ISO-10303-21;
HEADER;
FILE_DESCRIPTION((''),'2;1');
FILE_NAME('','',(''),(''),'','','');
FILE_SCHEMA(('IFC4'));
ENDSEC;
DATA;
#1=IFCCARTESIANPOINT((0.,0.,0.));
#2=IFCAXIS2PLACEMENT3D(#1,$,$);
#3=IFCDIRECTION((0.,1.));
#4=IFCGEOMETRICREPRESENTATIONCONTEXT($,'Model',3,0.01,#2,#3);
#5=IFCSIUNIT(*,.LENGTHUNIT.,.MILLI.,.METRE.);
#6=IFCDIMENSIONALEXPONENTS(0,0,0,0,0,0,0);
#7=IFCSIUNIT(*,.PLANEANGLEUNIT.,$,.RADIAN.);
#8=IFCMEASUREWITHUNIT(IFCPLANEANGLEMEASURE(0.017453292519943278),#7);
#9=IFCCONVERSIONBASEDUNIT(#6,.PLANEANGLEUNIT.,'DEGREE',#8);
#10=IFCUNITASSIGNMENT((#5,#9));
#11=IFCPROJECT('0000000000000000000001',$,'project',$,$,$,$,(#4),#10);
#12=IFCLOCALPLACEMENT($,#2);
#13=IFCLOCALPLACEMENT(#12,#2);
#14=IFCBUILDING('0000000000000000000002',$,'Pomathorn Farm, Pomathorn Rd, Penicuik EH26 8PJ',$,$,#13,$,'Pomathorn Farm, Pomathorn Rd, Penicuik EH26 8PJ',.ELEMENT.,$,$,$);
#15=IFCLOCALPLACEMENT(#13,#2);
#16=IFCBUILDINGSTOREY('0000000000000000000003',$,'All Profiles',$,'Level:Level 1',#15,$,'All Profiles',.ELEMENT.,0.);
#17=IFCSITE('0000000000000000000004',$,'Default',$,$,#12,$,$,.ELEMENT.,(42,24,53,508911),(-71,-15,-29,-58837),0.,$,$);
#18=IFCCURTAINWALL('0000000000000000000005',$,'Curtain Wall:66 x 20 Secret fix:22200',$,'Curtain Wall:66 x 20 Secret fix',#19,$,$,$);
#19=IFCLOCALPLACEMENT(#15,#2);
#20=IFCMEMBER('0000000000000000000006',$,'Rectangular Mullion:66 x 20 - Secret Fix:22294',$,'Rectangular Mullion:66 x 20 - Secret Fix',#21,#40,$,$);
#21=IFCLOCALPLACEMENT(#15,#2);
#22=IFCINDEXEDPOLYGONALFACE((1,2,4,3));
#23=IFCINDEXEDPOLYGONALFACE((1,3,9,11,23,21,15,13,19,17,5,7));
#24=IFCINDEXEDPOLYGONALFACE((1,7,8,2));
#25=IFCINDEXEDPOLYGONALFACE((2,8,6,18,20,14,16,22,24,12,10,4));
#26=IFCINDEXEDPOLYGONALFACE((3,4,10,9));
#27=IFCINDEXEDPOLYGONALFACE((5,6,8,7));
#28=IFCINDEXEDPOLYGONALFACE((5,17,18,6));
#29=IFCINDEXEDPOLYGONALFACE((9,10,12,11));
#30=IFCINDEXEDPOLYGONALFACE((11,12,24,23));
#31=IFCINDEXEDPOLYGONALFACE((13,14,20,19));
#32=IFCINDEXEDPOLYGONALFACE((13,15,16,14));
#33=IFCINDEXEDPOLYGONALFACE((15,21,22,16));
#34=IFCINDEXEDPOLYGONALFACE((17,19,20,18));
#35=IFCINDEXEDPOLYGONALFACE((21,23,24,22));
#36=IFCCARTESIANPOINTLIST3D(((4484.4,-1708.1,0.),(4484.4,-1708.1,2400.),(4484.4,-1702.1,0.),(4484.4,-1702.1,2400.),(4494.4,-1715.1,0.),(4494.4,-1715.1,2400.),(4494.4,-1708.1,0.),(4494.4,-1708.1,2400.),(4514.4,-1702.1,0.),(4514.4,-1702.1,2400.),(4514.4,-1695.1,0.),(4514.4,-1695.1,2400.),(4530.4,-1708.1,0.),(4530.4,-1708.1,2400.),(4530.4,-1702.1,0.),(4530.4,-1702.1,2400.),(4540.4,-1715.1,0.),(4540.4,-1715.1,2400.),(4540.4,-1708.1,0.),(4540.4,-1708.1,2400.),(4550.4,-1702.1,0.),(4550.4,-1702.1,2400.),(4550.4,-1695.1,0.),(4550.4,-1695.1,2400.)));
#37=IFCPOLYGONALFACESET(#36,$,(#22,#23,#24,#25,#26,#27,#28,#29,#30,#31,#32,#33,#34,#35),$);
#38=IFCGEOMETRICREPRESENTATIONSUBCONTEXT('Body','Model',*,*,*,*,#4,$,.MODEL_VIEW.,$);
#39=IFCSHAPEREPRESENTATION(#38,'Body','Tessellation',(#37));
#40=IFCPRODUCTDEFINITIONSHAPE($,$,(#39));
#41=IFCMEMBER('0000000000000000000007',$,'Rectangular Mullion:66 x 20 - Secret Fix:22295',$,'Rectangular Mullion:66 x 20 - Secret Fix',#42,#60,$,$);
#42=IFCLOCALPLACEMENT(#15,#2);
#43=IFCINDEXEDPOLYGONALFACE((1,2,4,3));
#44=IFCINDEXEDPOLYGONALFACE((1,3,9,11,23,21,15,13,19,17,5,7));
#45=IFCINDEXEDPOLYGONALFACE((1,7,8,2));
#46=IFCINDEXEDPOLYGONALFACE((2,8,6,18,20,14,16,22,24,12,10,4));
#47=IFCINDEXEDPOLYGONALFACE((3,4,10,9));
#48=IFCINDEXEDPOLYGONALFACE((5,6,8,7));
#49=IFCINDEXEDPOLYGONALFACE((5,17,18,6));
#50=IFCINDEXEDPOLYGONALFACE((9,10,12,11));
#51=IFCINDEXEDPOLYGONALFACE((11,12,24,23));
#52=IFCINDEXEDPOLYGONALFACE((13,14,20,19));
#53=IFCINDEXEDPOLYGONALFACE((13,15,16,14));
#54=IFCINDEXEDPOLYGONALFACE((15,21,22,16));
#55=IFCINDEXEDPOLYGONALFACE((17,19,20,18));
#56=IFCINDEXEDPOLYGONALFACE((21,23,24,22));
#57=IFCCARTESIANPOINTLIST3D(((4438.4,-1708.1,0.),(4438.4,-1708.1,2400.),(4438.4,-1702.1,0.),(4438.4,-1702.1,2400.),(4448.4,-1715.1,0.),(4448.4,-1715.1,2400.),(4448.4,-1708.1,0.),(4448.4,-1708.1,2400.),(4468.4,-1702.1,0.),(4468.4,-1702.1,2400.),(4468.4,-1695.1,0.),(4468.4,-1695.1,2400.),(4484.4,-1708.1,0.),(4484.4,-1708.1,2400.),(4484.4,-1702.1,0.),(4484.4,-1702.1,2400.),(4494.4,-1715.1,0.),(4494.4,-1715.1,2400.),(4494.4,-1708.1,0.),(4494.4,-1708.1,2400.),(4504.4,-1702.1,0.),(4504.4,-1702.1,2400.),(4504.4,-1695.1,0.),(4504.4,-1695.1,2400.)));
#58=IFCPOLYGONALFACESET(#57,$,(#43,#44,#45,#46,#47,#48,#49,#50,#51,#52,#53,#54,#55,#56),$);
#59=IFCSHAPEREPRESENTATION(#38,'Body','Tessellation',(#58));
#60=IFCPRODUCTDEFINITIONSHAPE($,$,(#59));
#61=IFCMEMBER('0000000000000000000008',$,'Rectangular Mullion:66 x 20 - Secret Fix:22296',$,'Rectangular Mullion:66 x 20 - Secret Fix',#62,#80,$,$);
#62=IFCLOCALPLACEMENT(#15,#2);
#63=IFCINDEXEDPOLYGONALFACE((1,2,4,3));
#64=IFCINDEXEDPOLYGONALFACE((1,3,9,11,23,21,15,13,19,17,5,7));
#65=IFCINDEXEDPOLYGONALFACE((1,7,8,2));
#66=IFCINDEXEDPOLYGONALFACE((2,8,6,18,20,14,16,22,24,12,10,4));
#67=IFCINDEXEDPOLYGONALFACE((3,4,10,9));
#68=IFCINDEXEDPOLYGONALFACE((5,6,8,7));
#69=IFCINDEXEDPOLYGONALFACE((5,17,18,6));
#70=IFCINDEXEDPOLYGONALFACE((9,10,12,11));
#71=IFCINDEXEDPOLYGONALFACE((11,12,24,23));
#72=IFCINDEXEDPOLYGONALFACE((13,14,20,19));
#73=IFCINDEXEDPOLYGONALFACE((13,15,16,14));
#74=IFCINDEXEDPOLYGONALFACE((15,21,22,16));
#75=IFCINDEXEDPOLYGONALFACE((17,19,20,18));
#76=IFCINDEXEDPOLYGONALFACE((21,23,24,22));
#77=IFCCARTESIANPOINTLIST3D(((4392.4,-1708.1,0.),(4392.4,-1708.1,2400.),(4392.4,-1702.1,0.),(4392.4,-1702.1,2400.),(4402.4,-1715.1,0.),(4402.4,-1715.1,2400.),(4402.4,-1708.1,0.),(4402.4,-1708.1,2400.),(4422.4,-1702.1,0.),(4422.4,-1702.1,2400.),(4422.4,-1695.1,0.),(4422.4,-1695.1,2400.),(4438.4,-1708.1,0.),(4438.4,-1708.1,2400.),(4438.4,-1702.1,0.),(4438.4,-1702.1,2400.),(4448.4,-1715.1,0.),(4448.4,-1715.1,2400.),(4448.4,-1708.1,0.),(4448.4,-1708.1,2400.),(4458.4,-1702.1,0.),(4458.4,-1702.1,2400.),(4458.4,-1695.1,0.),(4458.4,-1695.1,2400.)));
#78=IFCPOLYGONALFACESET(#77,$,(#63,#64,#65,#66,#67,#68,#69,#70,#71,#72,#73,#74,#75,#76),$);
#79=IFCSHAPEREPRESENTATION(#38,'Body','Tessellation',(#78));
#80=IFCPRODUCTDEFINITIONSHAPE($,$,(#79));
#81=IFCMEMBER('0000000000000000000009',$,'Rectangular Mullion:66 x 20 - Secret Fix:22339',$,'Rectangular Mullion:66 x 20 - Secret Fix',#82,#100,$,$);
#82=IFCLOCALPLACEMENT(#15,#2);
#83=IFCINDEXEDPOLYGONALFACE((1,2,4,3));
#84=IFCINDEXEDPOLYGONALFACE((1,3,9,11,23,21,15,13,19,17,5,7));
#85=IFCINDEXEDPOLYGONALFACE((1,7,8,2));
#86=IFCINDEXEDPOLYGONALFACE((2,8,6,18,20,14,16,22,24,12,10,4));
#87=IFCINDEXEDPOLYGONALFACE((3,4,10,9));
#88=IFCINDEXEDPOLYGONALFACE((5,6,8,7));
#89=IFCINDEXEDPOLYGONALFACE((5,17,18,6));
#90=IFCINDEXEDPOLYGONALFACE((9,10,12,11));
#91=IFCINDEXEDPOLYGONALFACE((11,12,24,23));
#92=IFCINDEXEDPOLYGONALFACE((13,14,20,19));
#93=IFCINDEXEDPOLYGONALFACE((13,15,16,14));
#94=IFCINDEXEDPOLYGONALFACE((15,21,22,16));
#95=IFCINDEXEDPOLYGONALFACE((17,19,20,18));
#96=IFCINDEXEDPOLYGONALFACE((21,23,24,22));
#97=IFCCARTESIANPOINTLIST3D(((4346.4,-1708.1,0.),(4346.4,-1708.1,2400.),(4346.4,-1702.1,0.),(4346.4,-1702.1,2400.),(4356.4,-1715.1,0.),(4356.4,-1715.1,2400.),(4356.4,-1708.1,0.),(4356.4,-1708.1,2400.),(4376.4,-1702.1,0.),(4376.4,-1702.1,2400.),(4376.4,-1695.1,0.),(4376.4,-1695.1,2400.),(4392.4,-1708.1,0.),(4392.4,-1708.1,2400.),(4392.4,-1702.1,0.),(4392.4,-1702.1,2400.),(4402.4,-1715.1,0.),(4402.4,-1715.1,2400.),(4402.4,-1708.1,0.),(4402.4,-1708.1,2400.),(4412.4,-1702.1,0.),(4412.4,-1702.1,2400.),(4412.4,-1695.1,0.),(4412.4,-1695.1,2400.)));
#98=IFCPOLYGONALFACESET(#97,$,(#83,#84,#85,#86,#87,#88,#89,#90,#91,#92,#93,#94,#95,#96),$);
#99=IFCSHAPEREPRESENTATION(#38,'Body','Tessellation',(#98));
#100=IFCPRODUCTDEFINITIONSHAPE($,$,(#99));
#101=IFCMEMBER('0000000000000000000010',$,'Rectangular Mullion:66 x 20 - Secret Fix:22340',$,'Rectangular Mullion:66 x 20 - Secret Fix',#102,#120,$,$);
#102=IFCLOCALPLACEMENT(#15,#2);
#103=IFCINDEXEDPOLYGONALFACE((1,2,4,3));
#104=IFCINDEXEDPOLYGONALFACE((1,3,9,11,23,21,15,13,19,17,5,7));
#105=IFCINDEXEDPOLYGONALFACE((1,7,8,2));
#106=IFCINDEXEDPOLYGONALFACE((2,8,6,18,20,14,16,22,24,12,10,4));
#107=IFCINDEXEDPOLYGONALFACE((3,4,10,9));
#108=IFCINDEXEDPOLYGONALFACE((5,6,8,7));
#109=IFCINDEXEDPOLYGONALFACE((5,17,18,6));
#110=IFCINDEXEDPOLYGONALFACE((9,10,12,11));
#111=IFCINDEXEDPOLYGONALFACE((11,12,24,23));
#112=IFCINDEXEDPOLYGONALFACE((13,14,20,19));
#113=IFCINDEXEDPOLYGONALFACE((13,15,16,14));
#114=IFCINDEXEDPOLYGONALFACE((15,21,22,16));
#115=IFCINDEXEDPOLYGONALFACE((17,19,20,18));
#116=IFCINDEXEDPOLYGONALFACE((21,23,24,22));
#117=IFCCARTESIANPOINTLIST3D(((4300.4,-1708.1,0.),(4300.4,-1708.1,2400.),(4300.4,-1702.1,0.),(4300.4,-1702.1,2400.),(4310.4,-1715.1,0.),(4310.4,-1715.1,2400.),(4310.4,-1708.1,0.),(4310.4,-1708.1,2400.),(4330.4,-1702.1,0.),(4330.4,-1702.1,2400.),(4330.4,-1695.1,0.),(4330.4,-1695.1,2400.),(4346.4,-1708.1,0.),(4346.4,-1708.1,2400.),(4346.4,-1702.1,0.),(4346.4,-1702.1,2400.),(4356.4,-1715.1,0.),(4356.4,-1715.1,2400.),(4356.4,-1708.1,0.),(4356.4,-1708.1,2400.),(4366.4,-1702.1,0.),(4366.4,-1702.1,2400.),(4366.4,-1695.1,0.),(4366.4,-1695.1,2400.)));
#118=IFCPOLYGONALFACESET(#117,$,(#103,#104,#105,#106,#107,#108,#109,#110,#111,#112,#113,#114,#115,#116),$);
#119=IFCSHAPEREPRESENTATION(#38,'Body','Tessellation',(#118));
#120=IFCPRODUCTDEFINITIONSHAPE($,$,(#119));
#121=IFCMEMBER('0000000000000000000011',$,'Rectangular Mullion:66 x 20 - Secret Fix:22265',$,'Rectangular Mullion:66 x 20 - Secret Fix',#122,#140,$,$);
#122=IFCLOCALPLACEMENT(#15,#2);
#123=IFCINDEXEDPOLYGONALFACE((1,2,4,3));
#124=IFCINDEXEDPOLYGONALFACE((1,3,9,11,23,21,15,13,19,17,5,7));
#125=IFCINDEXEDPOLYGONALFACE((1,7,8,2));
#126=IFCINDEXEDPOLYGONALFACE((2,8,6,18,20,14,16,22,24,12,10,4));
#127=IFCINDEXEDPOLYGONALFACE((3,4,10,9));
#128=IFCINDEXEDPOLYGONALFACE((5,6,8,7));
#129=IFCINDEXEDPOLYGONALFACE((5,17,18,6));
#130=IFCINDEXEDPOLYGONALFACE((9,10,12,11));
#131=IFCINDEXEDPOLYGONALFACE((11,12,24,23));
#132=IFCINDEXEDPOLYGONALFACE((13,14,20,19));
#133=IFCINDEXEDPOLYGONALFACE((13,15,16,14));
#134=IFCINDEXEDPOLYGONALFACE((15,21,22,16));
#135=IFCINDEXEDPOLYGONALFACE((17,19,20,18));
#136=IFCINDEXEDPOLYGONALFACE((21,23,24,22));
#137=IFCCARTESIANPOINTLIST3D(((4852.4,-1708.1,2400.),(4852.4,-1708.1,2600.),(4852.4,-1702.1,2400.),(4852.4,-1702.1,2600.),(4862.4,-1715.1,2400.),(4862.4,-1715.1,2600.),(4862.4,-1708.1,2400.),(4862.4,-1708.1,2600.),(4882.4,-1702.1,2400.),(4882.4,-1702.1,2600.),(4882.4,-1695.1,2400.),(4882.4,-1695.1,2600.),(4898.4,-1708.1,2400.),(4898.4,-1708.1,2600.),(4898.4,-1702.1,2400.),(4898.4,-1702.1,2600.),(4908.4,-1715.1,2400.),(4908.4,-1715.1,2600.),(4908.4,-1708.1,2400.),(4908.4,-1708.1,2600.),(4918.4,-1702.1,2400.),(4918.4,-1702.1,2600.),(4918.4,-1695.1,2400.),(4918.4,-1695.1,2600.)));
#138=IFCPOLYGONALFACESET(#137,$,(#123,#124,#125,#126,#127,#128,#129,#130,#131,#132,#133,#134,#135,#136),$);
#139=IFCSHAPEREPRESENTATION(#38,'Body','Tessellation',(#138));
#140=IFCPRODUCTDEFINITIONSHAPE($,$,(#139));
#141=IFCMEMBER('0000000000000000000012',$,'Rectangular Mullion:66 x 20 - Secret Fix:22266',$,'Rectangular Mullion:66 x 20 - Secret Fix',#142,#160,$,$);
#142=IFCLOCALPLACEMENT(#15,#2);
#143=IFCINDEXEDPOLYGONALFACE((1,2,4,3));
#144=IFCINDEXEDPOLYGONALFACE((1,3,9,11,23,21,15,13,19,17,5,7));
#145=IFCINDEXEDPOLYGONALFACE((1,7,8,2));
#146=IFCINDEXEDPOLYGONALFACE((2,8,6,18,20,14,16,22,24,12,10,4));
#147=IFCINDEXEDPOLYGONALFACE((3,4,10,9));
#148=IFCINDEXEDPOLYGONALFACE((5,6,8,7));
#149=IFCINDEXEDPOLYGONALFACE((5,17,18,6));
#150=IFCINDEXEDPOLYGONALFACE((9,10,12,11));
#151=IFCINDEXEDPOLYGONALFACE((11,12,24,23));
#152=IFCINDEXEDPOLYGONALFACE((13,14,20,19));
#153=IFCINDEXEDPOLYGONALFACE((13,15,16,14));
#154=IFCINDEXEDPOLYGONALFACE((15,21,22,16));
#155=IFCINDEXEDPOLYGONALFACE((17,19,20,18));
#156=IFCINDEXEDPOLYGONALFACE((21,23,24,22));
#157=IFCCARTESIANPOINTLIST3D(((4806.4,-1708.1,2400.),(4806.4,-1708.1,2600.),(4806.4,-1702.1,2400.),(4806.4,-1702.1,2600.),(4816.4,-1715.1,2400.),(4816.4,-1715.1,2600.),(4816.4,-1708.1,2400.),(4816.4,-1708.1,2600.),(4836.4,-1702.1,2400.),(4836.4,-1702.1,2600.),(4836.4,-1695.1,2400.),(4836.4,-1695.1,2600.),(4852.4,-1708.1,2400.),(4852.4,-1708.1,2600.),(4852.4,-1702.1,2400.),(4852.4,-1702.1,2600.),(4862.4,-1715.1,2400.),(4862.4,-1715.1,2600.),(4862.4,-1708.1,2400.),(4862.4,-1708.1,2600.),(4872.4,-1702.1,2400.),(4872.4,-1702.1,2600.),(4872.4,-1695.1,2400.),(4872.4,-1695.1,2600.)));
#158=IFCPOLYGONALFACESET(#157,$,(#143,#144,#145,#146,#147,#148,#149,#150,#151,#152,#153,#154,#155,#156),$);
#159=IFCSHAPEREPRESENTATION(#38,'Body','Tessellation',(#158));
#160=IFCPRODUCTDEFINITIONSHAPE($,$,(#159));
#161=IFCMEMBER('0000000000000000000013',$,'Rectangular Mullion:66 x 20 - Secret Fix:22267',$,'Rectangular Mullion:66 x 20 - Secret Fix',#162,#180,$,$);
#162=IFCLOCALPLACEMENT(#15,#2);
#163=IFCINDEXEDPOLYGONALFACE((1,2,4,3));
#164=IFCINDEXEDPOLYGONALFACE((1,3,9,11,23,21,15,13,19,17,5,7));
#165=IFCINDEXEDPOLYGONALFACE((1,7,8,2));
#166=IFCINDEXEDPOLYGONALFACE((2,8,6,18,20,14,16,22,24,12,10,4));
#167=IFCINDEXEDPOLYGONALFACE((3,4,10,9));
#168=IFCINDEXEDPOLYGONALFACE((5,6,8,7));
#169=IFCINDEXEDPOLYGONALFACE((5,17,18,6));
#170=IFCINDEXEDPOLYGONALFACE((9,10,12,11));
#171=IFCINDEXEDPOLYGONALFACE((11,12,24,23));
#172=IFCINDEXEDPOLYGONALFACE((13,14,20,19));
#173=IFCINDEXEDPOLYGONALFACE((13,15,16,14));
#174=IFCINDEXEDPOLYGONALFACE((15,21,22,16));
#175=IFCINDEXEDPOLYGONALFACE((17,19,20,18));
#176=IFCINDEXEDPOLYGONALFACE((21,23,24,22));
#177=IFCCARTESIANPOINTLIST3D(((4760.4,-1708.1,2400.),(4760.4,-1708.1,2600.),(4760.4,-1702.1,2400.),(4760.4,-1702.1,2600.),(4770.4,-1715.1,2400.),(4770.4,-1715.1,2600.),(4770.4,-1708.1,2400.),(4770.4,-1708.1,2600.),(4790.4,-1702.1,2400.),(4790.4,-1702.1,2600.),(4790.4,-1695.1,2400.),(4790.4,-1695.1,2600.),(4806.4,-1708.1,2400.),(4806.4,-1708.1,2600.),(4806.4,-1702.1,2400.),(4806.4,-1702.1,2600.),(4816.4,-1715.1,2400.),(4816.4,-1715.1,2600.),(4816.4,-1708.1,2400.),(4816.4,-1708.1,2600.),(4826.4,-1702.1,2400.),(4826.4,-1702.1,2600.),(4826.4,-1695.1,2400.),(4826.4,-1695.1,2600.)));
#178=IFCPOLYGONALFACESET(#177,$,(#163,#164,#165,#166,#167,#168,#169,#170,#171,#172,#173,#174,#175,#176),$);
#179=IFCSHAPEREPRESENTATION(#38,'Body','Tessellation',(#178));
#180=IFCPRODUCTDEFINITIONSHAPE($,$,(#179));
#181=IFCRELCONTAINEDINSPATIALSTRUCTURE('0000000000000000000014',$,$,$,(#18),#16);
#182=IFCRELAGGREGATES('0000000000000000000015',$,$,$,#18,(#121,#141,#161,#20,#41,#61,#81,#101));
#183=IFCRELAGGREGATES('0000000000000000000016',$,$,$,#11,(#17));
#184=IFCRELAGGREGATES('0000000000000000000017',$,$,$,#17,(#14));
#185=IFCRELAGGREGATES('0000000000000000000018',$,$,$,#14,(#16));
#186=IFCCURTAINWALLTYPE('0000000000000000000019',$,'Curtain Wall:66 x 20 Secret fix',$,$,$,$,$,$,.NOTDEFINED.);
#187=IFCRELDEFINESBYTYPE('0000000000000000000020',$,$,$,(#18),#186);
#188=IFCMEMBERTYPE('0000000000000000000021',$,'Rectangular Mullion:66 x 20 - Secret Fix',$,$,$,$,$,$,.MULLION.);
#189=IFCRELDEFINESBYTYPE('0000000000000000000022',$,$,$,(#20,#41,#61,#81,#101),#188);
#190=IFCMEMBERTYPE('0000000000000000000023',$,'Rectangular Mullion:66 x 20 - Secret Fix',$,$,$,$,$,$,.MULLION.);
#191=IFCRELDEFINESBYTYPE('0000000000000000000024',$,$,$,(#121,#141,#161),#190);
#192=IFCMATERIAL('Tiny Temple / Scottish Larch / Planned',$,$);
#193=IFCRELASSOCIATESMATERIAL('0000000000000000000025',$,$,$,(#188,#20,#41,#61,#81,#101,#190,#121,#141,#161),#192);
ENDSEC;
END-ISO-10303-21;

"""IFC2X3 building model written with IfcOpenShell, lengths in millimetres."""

from ifc_helpers import new_model, entity, si_unit, converted_unit, direction, frame, origin, place, context, subcontext, project, spatial, polyline, outline, extrude, source, transform, mapped, material, type_object, type_shapes, element, aggregate, save


model = new_model("IFC2X3")

# Units and contexts
model_context = context("Model", 3, precision=0.01, world=origin(), true_north=direction((0.0, 1.0)))
body_context = subcontext(model_context, "Body", "Model", "MODEL_VIEW")
ifc_project = project(units=[si_unit("LENGTHUNIT", "METRE", prefix="MILLI"), converted_unit("PLANEANGLEUNIT", "DEGREE", entity("IfcPlaneAngleMeasure", 0.017453292519943278), si_unit("PLANEANGLEUNIT", "RADIAN"), dimensions=[0, 0, 0, 0, 0, 0, 0])], contexts=[model_context])

# Site, building, storey
site_placement = place(None, origin())
site = spatial("IfcSite", under=ifc_project, at=site_placement, Name="Default", CompositionType="ELEMENT", RefLatitude=(42, 24, 53, 508911), RefLongitude=(-71, -15, -29, -58837), RefElevation=0.0)
building_placement = place(site_placement, origin())
building = spatial("IfcBuilding", under=site, at=building_placement, Name="Pomathorn Farm, Pomathorn Rd, Penicuik EH26 8PJ", LongName="Pomathorn Farm, Pomathorn Rd, Penicuik EH26 8PJ", CompositionType="ELEMENT")
storey_placement = place(building_placement, origin())
storey = spatial("IfcBuildingStorey", under=building, at=storey_placement, Name="All Profiles", ObjectType="Level:Level 1", LongName="All Profiles", CompositionType="ELEMENT", Elevation=0.0)

# Curtain wall, members
curtain_wall_type = type_object("IfcCurtainWallType", Name="Curtain Wall:66 x 20 Secret fix", PredefinedType="NOTDEFINED")
curtain_wall_placement = place(storey_placement, origin())
curtain_wall = element("IfcCurtainWall", 1, at=curtain_wall_placement, inside=storey, type_object=curtain_wall_type, Name="Curtain Wall:66 x 20 Secret fix:22200", ObjectType="Curtain Wall:66 x 20 Secret fix")
ifc_material = material(Name="Tiny Temple / Scottish Larch / Planned")
member_type_1 = type_object("IfcMemberType", Name="Rectangular Mullion:66 x 20 - Secret Fix", PredefinedType="MULLION", material=ifc_material)
shared_shape_1 = source(origin(), body_context, "Body", "SweptSolid", [
    extrude(outline(polyline([(-3.0, -34.7), (3.0, -34.7), (3.0, -4.7), (10.0, -4.7), (10.0, 31.3), (3.0, 31.3), (3.0, 11.3), (-3.0, 11.3), (-3.0, 21.3), (-10.0, 21.3), (-10.0, -24.7), (-3.0, -24.7), (-3.0, -34.7)])), frame((-31.3, -10.0, -2400.0), z_axis=(0.0, 0.0, 1.0), x_axis=(0.0, -1.0, 0.0)), (0.0, 0.0, 1.0), 2400.0),
])
type_shapes(member_type_1, [shared_shape_1])
member_1_placement = place(curtain_wall_placement, frame((4550.4, -1715.1, 0.0), z_axis=(0.0, 0.0, -1.0), x_axis=(1.0, 0.0, 0.0)))
member_1 = element("IfcMember", 2, at=member_1_placement, type_object=member_type_1, material=ifc_material, Name="Rectangular Mullion:66 x 20 - Secret Fix:22294", ObjectType="Rectangular Mullion:66 x 20 - Secret Fix", context=body_context, shape_type="MappedRepresentation", body=[
    mapped(shared_shape_1, transform((0.0, 0.0, 0.0), scale=1.0)),
])
member_2_placement = place(curtain_wall_placement, frame((4504.4, -1715.1, 0.0), z_axis=(0.0, 0.0, -1.0), x_axis=(1.0, 0.0, 0.0)))
member_2 = element("IfcMember", 3, at=member_2_placement, type_object=member_type_1, material=ifc_material, Name="Rectangular Mullion:66 x 20 - Secret Fix:22295", ObjectType="Rectangular Mullion:66 x 20 - Secret Fix", context=body_context, shape_type="MappedRepresentation", body=[
    mapped(shared_shape_1, transform((0.0, 0.0, 0.0), scale=1.0)),
])
member_3_placement = place(curtain_wall_placement, frame((4458.4, -1715.1, 0.0), z_axis=(0.0, 0.0, -1.0), x_axis=(1.0, 0.0, 0.0)))
member_3 = element("IfcMember", 4, at=member_3_placement, type_object=member_type_1, material=ifc_material, Name="Rectangular Mullion:66 x 20 - Secret Fix:22296", ObjectType="Rectangular Mullion:66 x 20 - Secret Fix", context=body_context, shape_type="MappedRepresentation", body=[
    mapped(shared_shape_1, transform((0.0, 0.0, 0.0), scale=1.0)),
])
member_4_placement = place(curtain_wall_placement, frame((4412.4, -1715.1, 0.0), z_axis=(0.0, 0.0, -1.0), x_axis=(1.0, 0.0, 0.0)))
member_4 = element("IfcMember", 5, at=member_4_placement, type_object=member_type_1, material=ifc_material, Name="Rectangular Mullion:66 x 20 - Secret Fix:22339", ObjectType="Rectangular Mullion:66 x 20 - Secret Fix", context=body_context, shape_type="MappedRepresentation", body=[
    mapped(shared_shape_1, transform((0.0, 0.0, 0.0), scale=1.0)),
])
member_5_placement = place(curtain_wall_placement, frame((4366.4, -1715.1, 0.0), z_axis=(0.0, 0.0, -1.0), x_axis=(1.0, 0.0, 0.0)))
member_5 = element("IfcMember", 6, at=member_5_placement, type_object=member_type_1, material=ifc_material, Name="Rectangular Mullion:66 x 20 - Secret Fix:22340", ObjectType="Rectangular Mullion:66 x 20 - Secret Fix", context=body_context, shape_type="MappedRepresentation", body=[
    mapped(shared_shape_1, transform((0.0, 0.0, 0.0), scale=1.0)),
])
member_type_2 = type_object("IfcMemberType", Name="Rectangular Mullion:66 x 20 - Secret Fix", PredefinedType="MULLION", material=ifc_material)
shared_shape_2 = source(origin(), body_context, "Body", "SweptSolid", [
    extrude(outline(polyline([(-3.0, -34.7), (3.0, -34.7), (3.0, -4.7), (10.0, -4.7), (10.0, 31.3), (3.0, 31.3), (3.0, 11.3), (-3.0, 11.3), (-3.0, 21.3), (-10.0, 21.3), (-10.0, -24.7), (-3.0, -24.7), (-3.0, -34.7)])), frame((-31.3, -10.0, -200.0), z_axis=(0.0, 0.0, 1.0), x_axis=(0.0, -1.0, 0.0)), (0.0, 0.0, 1.0), 200.0),
])
type_shapes(member_type_2, [shared_shape_2])
member_6_placement = place(curtain_wall_placement, frame((4918.4, -1715.1, 2400.0), z_axis=(0.0, 0.0, -1.0), x_axis=(1.0, 0.0, 0.0)))
member_6 = element("IfcMember", 7, at=member_6_placement, type_object=member_type_2, material=ifc_material, Name="Rectangular Mullion:66 x 20 - Secret Fix:22265", ObjectType="Rectangular Mullion:66 x 20 - Secret Fix", context=body_context, shape_type="MappedRepresentation", body=[
    mapped(shared_shape_2, transform((0.0, 0.0, 0.0), scale=1.0)),
])
member_7_placement = place(curtain_wall_placement, frame((4872.4, -1715.1, 2400.0), z_axis=(0.0, 0.0, -1.0), x_axis=(1.0, 0.0, 0.0)))
member_7 = element("IfcMember", 8, at=member_7_placement, type_object=member_type_2, material=ifc_material, Name="Rectangular Mullion:66 x 20 - Secret Fix:22266", ObjectType="Rectangular Mullion:66 x 20 - Secret Fix", context=body_context, shape_type="MappedRepresentation", body=[
    mapped(shared_shape_2, transform((0.0, 0.0, 0.0), scale=1.0)),
])
member_8_placement = place(curtain_wall_placement, frame((4826.4, -1715.1, 2400.0), z_axis=(0.0, 0.0, -1.0), x_axis=(1.0, 0.0, 0.0)))
member_8 = element("IfcMember", 9, at=member_8_placement, type_object=member_type_2, material=ifc_material, Name="Rectangular Mullion:66 x 20 - Secret Fix:22267", ObjectType="Rectangular Mullion:66 x 20 - Secret Fix", context=body_context, shape_type="MappedRepresentation", body=[
    mapped(shared_shape_2, transform((0.0, 0.0, 0.0), scale=1.0)),
])
aggregate(curtain_wall, [member_6, member_7, member_8, member_1, member_2, member_3, member_4, member_5])

save(model, "model.ifc")
